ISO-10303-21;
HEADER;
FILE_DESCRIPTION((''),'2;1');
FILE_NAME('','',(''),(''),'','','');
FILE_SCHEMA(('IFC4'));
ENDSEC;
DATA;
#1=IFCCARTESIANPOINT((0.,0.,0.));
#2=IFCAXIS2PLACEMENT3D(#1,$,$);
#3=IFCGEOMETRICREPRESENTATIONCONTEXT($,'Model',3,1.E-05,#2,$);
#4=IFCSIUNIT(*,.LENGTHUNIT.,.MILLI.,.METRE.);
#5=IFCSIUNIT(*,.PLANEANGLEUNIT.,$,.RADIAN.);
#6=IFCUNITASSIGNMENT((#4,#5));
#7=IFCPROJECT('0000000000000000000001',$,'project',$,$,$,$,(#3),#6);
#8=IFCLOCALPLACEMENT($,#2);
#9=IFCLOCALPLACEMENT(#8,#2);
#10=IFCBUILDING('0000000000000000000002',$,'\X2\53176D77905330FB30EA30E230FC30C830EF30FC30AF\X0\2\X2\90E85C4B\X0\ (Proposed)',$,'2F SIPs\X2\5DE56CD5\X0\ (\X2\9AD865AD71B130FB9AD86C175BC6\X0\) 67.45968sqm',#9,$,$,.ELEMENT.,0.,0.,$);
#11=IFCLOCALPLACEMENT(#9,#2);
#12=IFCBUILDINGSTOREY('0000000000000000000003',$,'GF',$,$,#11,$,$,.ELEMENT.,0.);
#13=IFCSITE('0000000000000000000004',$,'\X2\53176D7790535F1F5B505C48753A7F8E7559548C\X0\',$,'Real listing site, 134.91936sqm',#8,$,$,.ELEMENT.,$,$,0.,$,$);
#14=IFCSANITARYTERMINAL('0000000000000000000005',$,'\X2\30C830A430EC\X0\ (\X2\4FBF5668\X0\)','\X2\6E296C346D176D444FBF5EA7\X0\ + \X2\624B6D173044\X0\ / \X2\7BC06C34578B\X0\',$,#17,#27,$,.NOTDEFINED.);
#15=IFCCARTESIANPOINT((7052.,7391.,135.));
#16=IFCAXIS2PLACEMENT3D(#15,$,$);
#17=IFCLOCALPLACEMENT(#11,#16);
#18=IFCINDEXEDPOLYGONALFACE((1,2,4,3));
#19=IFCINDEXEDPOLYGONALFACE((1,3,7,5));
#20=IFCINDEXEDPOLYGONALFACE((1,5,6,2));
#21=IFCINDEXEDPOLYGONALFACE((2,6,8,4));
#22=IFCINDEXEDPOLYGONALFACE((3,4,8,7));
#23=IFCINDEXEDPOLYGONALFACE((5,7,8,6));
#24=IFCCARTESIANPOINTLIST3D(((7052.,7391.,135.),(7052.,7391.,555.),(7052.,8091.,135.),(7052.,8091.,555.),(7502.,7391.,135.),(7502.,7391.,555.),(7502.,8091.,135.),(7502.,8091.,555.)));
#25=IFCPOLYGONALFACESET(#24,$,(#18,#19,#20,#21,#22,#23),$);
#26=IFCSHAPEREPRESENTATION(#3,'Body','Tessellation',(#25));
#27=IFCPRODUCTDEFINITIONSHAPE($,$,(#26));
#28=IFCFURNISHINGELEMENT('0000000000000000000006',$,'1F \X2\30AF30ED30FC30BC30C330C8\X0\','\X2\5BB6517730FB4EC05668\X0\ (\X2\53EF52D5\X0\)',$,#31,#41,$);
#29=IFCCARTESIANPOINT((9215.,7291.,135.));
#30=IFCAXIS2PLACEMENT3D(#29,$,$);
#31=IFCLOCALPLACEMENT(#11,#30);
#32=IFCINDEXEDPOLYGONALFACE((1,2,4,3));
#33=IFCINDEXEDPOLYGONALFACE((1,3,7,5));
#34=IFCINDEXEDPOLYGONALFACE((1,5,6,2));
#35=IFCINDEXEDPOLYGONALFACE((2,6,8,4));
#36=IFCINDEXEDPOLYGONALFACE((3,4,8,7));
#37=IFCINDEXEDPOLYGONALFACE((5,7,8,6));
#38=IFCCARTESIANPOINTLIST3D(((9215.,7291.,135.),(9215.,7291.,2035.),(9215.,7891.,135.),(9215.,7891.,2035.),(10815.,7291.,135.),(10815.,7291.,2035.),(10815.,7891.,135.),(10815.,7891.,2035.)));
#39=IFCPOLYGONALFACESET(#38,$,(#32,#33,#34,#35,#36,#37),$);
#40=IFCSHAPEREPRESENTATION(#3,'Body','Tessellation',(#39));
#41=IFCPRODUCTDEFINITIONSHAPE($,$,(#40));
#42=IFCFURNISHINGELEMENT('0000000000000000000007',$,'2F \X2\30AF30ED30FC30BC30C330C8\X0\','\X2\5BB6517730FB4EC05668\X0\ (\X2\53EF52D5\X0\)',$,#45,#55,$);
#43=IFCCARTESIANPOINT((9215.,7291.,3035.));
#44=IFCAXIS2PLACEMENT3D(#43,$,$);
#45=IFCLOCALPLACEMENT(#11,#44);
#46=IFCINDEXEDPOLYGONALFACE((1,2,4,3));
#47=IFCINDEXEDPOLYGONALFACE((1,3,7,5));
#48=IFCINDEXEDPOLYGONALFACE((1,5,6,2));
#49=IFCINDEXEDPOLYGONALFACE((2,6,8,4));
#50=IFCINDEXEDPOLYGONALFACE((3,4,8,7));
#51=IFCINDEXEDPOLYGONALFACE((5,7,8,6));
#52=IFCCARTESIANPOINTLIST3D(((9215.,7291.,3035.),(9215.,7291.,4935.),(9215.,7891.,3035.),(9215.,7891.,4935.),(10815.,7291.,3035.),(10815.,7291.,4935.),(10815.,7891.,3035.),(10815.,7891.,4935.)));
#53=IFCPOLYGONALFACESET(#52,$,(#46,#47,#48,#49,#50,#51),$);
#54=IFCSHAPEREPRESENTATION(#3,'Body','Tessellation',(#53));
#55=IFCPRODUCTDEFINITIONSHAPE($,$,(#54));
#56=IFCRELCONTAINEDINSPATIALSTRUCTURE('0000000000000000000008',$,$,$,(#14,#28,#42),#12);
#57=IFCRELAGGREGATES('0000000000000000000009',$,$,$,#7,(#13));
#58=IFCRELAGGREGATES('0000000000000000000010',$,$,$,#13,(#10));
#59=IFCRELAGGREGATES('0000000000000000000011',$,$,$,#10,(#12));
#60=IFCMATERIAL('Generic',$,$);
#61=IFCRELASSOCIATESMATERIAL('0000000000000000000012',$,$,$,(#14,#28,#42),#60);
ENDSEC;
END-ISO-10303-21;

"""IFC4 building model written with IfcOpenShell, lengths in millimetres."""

from ifc_helpers import new_model, si_unit, frame, frame_2d, origin, place, context, project, spatial, rectangle, extrude, material, element, save


model = new_model("IFC4")

# Units and contexts
model_context = context("Model", 3, precision=1e-05, world=origin())
ifc_project = project(units=[si_unit("LENGTHUNIT", "METRE", prefix="MILLI"), si_unit("PLANEANGLEUNIT", "RADIAN")], contexts=[model_context])

# Site, building, storey
site_placement = place(None, origin())
site = spatial("IfcSite", under=ifc_project, at=site_placement, Name="北海道弟子屈町美留和", ObjectType="Real listing site, 134.91936sqm", CompositionType="ELEMENT", RefElevation=0.0)
building_placement = place(site_placement, origin())
building = spatial("IfcBuilding", under=site, at=building_placement, Name="北海道・リモートワーク2部屋 (Proposed)", ObjectType="2F SIPs工法 (高断熱・高気密) 67.45968sqm", CompositionType="ELEMENT", ElevationOfRefHeight=0.0, ElevationOfTerrain=0.0)
storey_placement = place(building_placement, origin())
storey = spatial("IfcBuildingStorey", under=building, at=storey_placement, Name="GF", CompositionType="ELEMENT", Elevation=0.0)

# Shared definitions
ifc_material_1 = material(Name="Generic")

# Sanitary terminal
sanitary_terminal_1_placement = place(storey_placement, frame((7052.0, 7391.0, 135.0)))
element("IfcSanitaryTerminal", 1, at=sanitary_terminal_1_placement, inside=storey, material=ifc_material_1, Name="トイレ (便器)", Description="温水洗浄便座 + 手洗い / 節水型", PredefinedType="NOTDEFINED", context=model_context, shape_type="SweptSolid", body=[
    extrude(rectangle(XDim=450.0, YDim=700.0, at=frame_2d((225.0, 350.0))), frame((7052.0, 7391.0, 135.0)), (0.0, 0.0, 1.0), 420.0),
])

# Furnishing elements
furnishing_1_placement = place(storey_placement, frame((9215.0, 7291.0, 135.0)))
element("IfcFurnishingElement", 2, at=furnishing_1_placement, inside=storey, material=ifc_material_1, Name="1F クローゼット", Description="家具・什器 (可動)", context=model_context, shape_type="SweptSolid", body=[
    extrude(rectangle(XDim=1600.0, YDim=600.0, at=frame_2d((800.0, 300.0))), frame((9215.0, 7291.0, 135.0)), (0.0, 0.0, 1.0), 1900.0),
])
furnishing_2_placement = place(storey_placement, frame((9215.0, 7291.0, 3035.0)))
element("IfcFurnishingElement", 3, at=furnishing_2_placement, inside=storey, material=ifc_material_1, Name="2F クローゼット", Description="家具・什器 (可動)", context=model_context, shape_type="SweptSolid", body=[
    extrude(rectangle(XDim=1600.0, YDim=600.0, at=frame_2d((800.0, 300.0))), frame((9215.0, 7291.0, 3035.0)), (0.0, 0.0, 1.0), 1900.0),
])

save(model, "model.ifc")
